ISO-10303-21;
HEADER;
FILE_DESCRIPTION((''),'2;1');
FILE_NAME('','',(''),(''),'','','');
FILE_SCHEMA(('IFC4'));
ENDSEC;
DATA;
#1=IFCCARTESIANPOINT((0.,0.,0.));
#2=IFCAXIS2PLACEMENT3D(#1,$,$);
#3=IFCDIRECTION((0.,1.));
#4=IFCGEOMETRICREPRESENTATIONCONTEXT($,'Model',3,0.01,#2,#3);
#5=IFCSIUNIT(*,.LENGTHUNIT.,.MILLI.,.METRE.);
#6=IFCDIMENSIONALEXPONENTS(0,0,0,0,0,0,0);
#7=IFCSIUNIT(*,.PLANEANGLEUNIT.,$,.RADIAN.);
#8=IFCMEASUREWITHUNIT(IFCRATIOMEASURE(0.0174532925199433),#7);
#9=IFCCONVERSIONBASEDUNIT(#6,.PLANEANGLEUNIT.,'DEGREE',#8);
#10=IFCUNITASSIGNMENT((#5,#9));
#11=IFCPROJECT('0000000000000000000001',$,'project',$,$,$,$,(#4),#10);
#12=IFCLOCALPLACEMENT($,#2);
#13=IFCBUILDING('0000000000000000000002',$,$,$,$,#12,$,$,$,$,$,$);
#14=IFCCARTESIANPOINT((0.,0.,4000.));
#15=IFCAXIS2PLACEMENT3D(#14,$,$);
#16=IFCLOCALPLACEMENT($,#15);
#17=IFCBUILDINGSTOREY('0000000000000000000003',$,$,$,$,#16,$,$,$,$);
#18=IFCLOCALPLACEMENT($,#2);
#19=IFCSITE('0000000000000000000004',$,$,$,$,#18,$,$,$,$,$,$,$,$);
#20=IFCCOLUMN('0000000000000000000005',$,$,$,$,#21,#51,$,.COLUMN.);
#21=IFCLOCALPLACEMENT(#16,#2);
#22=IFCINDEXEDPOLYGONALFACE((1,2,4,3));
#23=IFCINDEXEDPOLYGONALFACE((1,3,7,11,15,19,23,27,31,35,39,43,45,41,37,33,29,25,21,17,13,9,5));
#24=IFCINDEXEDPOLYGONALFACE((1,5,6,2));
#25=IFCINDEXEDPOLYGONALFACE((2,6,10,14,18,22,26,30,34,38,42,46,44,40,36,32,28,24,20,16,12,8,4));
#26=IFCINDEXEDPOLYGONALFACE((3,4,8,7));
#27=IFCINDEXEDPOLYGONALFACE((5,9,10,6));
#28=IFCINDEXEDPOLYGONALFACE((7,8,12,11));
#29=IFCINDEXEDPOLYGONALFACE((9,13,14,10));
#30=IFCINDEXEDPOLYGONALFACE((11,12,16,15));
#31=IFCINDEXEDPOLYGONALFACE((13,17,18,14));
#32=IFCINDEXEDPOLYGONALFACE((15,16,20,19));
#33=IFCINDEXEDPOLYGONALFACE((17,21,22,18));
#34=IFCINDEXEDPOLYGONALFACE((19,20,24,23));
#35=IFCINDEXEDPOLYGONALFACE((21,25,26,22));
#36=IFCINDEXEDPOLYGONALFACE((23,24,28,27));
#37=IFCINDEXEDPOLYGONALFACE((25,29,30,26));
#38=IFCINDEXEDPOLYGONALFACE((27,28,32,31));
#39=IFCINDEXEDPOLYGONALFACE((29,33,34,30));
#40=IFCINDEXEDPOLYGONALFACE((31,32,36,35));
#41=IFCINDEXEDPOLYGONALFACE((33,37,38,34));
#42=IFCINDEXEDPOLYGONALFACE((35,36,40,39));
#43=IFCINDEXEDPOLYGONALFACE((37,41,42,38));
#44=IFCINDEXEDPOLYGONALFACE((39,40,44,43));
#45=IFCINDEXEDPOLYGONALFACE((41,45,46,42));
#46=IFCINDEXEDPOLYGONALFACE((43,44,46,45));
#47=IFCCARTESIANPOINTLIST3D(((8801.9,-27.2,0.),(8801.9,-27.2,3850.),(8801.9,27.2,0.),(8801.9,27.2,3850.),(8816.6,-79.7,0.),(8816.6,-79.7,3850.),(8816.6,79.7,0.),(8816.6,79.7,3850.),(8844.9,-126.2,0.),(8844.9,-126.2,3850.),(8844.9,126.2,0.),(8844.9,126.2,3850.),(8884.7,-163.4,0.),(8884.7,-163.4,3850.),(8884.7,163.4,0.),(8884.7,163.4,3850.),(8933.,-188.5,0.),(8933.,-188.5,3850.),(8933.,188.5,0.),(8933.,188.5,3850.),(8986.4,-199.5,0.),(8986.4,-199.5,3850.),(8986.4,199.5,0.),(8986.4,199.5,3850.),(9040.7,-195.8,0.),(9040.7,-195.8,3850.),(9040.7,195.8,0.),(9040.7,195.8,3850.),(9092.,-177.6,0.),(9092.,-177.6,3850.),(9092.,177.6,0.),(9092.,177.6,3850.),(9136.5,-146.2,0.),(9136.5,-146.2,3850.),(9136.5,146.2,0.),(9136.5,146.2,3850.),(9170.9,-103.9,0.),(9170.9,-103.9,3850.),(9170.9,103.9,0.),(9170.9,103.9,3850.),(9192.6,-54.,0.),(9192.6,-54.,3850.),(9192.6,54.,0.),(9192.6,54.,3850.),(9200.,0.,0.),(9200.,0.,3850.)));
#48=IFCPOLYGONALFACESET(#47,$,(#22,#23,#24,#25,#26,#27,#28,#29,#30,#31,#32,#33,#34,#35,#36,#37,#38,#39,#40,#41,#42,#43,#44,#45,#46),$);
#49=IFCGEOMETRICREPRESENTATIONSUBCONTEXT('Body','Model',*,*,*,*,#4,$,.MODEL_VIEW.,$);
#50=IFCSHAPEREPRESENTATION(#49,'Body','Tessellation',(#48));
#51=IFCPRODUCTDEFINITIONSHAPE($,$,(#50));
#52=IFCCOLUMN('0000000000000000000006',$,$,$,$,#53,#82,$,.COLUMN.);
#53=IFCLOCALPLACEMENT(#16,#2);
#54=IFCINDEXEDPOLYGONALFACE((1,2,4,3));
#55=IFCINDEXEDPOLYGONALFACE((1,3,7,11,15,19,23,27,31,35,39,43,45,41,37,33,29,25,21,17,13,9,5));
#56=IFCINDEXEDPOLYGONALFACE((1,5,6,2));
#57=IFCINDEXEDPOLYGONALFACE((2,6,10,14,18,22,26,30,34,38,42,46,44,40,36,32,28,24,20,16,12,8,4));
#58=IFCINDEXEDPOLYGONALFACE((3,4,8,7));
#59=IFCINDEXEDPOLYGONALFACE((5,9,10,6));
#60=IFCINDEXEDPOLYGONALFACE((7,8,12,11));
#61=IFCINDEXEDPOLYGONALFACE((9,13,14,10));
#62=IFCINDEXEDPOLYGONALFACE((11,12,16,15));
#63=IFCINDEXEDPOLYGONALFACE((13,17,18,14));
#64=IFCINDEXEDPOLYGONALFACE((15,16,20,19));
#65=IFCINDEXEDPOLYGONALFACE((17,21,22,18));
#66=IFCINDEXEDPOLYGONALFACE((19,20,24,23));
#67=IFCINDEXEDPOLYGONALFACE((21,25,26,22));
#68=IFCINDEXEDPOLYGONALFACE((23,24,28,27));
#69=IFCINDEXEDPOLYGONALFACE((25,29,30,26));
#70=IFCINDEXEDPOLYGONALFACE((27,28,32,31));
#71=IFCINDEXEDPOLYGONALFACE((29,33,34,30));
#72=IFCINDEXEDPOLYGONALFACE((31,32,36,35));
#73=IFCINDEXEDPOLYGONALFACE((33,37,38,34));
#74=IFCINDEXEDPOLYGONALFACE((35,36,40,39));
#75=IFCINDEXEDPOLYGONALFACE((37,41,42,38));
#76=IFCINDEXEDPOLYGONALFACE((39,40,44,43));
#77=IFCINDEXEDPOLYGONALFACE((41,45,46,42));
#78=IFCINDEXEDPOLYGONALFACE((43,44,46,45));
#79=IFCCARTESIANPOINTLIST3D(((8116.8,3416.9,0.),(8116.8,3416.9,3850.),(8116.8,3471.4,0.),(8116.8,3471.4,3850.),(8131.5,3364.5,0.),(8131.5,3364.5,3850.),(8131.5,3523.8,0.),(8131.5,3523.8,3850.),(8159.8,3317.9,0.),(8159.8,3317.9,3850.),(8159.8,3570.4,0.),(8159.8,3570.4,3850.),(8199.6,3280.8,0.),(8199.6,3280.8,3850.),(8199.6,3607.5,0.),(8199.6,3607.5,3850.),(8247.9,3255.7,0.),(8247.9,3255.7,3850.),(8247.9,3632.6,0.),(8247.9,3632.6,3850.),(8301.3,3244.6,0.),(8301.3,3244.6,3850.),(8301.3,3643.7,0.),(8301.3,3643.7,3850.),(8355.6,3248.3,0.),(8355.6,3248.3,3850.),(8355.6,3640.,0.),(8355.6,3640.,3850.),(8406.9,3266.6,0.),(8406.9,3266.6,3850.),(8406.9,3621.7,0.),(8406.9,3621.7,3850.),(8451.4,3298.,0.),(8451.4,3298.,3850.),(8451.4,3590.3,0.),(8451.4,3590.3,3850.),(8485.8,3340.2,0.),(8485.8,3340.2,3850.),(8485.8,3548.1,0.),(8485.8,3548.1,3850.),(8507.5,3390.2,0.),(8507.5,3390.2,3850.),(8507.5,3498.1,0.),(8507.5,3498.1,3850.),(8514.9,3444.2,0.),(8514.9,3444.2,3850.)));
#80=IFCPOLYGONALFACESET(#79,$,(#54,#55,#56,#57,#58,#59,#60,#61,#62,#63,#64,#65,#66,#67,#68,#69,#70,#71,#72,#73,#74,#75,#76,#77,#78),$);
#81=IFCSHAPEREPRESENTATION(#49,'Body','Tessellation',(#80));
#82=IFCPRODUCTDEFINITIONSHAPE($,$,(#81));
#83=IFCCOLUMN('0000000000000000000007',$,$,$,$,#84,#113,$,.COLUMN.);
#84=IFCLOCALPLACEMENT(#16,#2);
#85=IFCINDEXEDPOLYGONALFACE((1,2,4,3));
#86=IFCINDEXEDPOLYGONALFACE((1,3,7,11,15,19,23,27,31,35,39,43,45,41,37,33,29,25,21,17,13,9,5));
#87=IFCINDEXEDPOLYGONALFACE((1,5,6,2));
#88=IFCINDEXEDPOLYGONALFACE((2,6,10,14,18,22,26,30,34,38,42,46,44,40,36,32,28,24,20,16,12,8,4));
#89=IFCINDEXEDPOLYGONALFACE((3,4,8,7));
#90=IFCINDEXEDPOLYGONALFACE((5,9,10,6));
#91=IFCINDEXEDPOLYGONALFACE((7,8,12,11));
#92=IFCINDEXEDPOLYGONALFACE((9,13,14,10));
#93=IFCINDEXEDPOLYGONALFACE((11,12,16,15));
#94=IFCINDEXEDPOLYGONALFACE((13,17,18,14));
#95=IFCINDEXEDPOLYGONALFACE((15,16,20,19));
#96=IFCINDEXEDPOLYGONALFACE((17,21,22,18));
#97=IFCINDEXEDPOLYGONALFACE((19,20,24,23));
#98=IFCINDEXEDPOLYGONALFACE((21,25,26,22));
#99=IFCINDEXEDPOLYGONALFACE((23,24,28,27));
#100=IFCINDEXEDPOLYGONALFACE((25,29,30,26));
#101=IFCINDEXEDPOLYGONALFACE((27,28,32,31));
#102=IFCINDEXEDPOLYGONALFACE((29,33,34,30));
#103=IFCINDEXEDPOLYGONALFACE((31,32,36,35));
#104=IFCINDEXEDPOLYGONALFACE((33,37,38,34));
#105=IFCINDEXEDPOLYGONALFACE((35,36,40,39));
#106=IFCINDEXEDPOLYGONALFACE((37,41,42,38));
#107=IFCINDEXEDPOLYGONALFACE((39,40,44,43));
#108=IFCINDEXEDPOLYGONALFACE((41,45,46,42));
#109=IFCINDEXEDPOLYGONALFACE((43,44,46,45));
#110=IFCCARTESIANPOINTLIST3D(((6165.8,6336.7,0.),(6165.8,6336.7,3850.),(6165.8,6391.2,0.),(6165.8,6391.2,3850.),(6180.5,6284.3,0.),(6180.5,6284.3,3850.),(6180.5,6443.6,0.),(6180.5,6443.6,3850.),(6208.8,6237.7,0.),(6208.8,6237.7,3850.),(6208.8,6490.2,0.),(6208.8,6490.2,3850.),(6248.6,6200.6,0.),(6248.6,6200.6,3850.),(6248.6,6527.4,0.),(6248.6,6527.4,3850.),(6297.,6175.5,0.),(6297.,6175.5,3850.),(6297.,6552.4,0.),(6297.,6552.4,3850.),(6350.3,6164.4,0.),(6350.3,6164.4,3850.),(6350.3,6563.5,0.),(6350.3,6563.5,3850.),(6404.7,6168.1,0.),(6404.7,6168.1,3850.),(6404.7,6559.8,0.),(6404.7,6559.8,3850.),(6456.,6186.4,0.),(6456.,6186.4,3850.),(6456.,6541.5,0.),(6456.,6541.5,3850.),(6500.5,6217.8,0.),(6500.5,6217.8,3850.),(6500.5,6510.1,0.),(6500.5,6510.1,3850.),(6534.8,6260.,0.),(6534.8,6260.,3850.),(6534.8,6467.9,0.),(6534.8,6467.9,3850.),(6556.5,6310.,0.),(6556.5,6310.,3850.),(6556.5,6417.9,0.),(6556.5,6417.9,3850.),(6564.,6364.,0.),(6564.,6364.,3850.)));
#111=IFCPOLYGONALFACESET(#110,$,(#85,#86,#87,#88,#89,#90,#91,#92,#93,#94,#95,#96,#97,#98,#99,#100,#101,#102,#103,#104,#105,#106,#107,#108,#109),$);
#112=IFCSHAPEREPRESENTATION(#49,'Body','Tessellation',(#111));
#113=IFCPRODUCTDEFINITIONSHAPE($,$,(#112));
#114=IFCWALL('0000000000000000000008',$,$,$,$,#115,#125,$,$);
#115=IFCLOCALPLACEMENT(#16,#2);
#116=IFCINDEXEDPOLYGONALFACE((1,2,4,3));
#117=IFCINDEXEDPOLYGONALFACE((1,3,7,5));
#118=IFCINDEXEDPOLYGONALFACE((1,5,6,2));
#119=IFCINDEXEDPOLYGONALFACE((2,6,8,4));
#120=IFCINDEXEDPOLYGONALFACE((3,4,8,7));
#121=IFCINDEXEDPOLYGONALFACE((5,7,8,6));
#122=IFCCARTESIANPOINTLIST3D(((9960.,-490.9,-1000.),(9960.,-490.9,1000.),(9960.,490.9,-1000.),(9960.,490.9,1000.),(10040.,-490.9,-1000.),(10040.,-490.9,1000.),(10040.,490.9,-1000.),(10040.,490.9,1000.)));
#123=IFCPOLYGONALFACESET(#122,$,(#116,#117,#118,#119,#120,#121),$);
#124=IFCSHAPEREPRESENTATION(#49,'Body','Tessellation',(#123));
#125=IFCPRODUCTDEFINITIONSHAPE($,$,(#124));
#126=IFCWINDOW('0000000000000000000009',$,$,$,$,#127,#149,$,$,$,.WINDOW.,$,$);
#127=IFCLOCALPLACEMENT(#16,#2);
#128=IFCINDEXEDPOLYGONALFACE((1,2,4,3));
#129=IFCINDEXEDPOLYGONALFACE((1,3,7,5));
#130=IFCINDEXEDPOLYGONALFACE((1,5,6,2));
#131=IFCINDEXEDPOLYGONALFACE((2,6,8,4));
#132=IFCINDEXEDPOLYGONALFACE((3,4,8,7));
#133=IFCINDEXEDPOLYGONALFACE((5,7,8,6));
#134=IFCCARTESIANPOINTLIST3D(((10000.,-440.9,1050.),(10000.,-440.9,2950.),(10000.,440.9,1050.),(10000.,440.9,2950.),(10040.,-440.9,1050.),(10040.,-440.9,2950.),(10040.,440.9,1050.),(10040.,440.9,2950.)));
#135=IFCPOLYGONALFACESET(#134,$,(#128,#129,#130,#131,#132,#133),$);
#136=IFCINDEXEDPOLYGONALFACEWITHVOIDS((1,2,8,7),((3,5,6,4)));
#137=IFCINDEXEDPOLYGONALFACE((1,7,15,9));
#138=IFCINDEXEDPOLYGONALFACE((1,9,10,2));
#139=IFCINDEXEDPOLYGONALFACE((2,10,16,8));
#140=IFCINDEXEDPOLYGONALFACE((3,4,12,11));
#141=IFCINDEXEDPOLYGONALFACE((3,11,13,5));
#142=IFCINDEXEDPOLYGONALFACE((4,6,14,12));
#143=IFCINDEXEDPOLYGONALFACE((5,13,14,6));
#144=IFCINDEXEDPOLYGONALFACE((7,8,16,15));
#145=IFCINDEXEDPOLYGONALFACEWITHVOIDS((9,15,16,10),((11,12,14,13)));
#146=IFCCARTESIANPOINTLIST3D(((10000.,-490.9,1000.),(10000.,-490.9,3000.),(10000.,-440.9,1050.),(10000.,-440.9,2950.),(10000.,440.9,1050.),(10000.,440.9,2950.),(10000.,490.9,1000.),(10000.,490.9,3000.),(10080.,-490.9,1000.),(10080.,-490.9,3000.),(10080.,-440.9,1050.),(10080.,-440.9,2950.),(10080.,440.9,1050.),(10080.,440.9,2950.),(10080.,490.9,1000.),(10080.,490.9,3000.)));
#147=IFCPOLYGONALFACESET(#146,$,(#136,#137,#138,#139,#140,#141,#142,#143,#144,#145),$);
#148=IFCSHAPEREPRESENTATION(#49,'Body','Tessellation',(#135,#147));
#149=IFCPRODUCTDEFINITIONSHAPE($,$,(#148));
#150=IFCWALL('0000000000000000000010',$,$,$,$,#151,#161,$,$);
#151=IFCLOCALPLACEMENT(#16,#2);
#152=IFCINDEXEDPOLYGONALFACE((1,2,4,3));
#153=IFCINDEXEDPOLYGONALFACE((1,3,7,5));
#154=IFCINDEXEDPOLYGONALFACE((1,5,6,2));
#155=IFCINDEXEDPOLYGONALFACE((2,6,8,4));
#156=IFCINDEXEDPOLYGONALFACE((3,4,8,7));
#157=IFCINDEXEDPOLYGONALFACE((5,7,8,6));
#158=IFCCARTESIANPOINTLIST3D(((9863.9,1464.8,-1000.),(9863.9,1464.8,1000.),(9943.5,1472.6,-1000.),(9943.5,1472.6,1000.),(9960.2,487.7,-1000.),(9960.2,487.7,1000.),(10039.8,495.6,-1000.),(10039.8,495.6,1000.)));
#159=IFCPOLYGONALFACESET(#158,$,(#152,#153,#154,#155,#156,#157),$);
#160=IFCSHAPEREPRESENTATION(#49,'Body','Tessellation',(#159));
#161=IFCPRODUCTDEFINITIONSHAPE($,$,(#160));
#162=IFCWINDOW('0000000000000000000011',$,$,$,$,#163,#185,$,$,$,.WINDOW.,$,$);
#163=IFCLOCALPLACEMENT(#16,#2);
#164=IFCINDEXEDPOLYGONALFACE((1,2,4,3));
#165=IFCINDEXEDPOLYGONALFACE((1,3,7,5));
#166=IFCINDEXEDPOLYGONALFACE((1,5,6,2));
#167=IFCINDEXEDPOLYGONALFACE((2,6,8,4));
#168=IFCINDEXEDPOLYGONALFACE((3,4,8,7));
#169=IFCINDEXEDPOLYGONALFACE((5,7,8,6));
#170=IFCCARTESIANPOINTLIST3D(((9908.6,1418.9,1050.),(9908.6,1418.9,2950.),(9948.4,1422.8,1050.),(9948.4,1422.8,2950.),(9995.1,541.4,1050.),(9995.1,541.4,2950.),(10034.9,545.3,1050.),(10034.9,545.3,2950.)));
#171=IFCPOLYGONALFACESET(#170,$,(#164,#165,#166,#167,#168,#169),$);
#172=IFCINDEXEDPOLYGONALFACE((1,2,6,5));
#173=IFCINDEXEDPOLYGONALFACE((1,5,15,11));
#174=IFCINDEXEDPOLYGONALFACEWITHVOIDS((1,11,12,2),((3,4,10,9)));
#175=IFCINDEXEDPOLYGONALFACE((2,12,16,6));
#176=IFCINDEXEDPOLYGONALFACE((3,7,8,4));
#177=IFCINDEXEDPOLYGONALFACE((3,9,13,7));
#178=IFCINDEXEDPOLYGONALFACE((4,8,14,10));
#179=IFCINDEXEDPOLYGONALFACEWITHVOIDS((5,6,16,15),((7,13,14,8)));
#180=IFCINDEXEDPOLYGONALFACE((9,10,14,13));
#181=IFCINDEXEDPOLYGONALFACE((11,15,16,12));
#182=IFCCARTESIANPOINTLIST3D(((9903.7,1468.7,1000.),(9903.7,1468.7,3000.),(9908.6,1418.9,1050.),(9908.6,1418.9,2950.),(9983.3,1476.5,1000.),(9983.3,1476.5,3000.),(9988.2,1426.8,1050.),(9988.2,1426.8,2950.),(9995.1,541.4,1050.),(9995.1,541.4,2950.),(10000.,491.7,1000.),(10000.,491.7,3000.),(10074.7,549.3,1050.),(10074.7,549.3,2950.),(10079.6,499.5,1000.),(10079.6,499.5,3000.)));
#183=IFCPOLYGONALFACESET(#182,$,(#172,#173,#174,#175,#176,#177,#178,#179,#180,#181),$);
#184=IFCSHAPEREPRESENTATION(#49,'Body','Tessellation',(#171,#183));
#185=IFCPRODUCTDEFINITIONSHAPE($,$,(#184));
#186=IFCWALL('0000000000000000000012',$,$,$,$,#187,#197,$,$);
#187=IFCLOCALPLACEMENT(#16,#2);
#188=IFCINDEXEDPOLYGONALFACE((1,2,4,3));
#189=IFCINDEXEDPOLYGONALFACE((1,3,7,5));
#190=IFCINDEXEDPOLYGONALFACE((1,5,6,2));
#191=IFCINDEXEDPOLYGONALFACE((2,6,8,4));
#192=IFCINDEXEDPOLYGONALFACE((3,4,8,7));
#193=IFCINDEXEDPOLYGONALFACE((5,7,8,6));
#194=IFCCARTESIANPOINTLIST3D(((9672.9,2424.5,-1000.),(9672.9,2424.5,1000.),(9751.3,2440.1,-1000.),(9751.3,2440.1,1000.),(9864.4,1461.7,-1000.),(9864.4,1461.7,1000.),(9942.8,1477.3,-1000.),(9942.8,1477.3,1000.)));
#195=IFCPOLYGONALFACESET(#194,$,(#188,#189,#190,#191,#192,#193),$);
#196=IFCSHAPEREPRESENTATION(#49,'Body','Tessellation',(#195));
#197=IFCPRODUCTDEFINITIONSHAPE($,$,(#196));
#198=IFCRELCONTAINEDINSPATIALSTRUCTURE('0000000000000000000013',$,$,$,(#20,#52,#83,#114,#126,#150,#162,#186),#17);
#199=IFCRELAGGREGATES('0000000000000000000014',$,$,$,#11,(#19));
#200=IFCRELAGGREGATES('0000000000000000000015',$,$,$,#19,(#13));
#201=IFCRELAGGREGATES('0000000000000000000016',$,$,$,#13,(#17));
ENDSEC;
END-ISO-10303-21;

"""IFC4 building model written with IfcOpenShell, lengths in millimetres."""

from ifc_helpers import new_model, entity, si_unit, converted_unit, direction, frame, origin, origin_2d, place, context, subcontext, project, spatial, rectangle, circle, extrude, element, save


model = new_model("IFC4")

# Units and contexts
model_context = context("Model", 3, precision=0.01, world=origin(), true_north=direction((0.0, 1.0)))
body_context = subcontext(model_context, "Body", "Model", "MODEL_VIEW")
ifc_project = project(units=[si_unit("LENGTHUNIT", "METRE", prefix="MILLI"), converted_unit("PLANEANGLEUNIT", "DEGREE", entity("IfcRatioMeasure", 0.0174532925199433), si_unit("PLANEANGLEUNIT", "RADIAN"), dimensions=[0, 0, 0, 0, 0, 0, 0])], contexts=[model_context])

# Site, building, storey
site_placement = place(None, origin())
site = spatial("IfcSite", under=ifc_project, at=site_placement)
building_placement = place(None, origin())
building = spatial("IfcBuilding", under=site, at=building_placement)
storey_placement = place(None, frame((0.0, 0.0, 4000.0)))
storey = spatial("IfcBuildingStorey", under=building, at=storey_placement)

# Columns
for number, where in (
    (1, (9000.0, 0.0, 0.0)),
    (2, (8314.9, 3444.2, 0.0)),
    (3, (6364.0, 6364.0, 0.0)),
):
    element("IfcColumn", number, at=place(storey_placement, frame(where)), inside=storey, PredefinedType="COLUMN", context=body_context, shape_type="SweptSolid", body=[
        extrude(circle(Radius=200.0, at=origin_2d()), origin(), (0.0, 0.0, 1.0), 3850.0),
    ])

# Wall
wall_1_placement = place(storey_placement, frame((10000.0, 0.0, -1000.0), z_axis=(0.0, 0.0, 1.0), x_axis=(0.0, 10000.0, 0.0)))
element("IfcWall", 4, at=wall_1_placement, inside=storey, context=body_context, shape_type="SweptSolid", body=[
    extrude(rectangle(XDim=981.7, YDim=80.0, at=origin_2d()), origin(), (0.0, 0.0, 1.0), 2000.0),
])

# Window
cartesian_point_1 = entity("IfcCartesianPoint", [-440.9, -950.0])
shared_polyline = entity("IfcPolyline", [cartesian_point_1, entity("IfcCartesianPoint", [-440.9, 950.0]), entity("IfcCartesianPoint", [-440.9, 950.0]), entity("IfcCartesianPoint", [440.9, 950.0]), entity("IfcCartesianPoint", [440.9, 950.0]), entity("IfcCartesianPoint", [440.9, -950.0]), entity("IfcCartesianPoint", [440.9, -950.0]), entity("IfcCartesianPoint", [-440.9, -950.0]), cartesian_point_1])
window_1_placement = place(storey_placement, frame((10000.0, 0.0, 2000.0), z_axis=(0.0, 0.0, 1.0), x_axis=(0.0, 10000.0, 0.0)))
cartesian_point_2 = entity("IfcCartesianPoint", [-490.9, -1000.0])
element("IfcWindow", 5, at=window_1_placement, inside=storey, PredefinedType="WINDOW", context=body_context, shape_type="SweptSolid", body=[
    entity("IfcExtrudedAreaSolid", entity("IfcArbitraryClosedProfileDef", "AREA", None, shared_polyline), entity("IfcAxis2Placement3D", entity("IfcCartesianPoint", [0.0, 0.0, 0.0]), entity("IfcDirection", [0.0, -1.0, 0.0]), entity("IfcDirection", [1.0, 0.0, 0.0])), entity("IfcDirection", [0.0, 0.0, 1.0]), 40.0),
    entity("IfcExtrudedAreaSolid", entity("IfcArbitraryProfileDefWithVoids", "AREA", None, entity("IfcPolyline", [cartesian_point_2, entity("IfcCartesianPoint", [-490.9, 1000.0]), entity("IfcCartesianPoint", [-490.9, 1000.0]), entity("IfcCartesianPoint", [490.9, 1000.0]), entity("IfcCartesianPoint", [490.9, 1000.0]), entity("IfcCartesianPoint", [490.9, -1000.0]), entity("IfcCartesianPoint", [490.9, -1000.0]), entity("IfcCartesianPoint", [-490.9, -1000.0]), cartesian_point_2]), [shared_polyline]), entity("IfcAxis2Placement3D", entity("IfcCartesianPoint", [0.0, 0.0, 0.0]), entity("IfcDirection", [0.0, -1.0, 0.0]), entity("IfcDirection", [1.0, 0.0, 0.0])), entity("IfcDirection", [0.0, 0.0, 1.0]), 80.0),
])

# Wall
wall_2_placement = place(storey_placement, frame((9951.8, 980.2, -1000.0), z_axis=(0.0, 0.0, 1.0), x_axis=(-980.17143, 9951.847264, 0.0)))
element("IfcWall", 6, at=wall_2_placement, inside=storey, context=body_context, shape_type="SweptSolid", body=[
    extrude(rectangle(XDim=981.7, YDim=80.0, at=origin_2d()), origin(), (0.0, 0.0, 1.0), 2000.0),
])

# Window
window_2_placement = place(storey_placement, frame((9951.8, 980.2, 2000.0), z_axis=(0.0, 0.0, 1.0), x_axis=(-980.17143, 9951.847264, 0.0)))
cartesian_point_3 = entity("IfcCartesianPoint", [-490.9, -1000.0])
element("IfcWindow", 7, at=window_2_placement, inside=storey, PredefinedType="WINDOW", context=body_context, shape_type="SweptSolid", body=[
    entity("IfcExtrudedAreaSolid", entity("IfcArbitraryClosedProfileDef", "AREA", None, shared_polyline), entity("IfcAxis2Placement3D", entity("IfcCartesianPoint", [0.0, 0.0, 0.0]), entity("IfcDirection", [0.0, -1.0, 0.0]), entity("IfcDirection", [1.0, 0.0, 0.0])), entity("IfcDirection", [0.0, 0.0, 1.0]), 40.0),
    entity("IfcExtrudedAreaSolid", entity("IfcArbitraryProfileDefWithVoids", "AREA", None, entity("IfcPolyline", [cartesian_point_3, entity("IfcCartesianPoint", [-490.9, 1000.0]), entity("IfcCartesianPoint", [-490.9, 1000.0]), entity("IfcCartesianPoint", [490.9, 1000.0]), entity("IfcCartesianPoint", [490.9, 1000.0]), entity("IfcCartesianPoint", [490.9, -1000.0]), entity("IfcCartesianPoint", [490.9, -1000.0]), entity("IfcCartesianPoint", [-490.9, -1000.0]), cartesian_point_3]), [shared_polyline]), entity("IfcAxis2Placement3D", entity("IfcCartesianPoint", [0.0, 0.0, 0.0]), entity("IfcDirection", [0.0, -1.0, 0.0]), entity("IfcDirection", [1.0, 0.0, 0.0])), entity("IfcDirection", [0.0, 0.0, 1.0]), 80.0),
])

# Wall
wall_3_placement = place(storey_placement, frame((9807.9, 1950.9, -1000.0), z_axis=(0.0, 0.0, 1.0), x_axis=(-1950.903274, 9807.852793, 0.0)))
element("IfcWall", 8, at=wall_3_placement, inside=storey, context=body_context, shape_type="SweptSolid", body=[
    extrude(rectangle(XDim=981.7, YDim=80.0, at=origin_2d()), origin(), (0.0, 0.0, 1.0), 2000.0),
])

save(model, "model.ifc")
